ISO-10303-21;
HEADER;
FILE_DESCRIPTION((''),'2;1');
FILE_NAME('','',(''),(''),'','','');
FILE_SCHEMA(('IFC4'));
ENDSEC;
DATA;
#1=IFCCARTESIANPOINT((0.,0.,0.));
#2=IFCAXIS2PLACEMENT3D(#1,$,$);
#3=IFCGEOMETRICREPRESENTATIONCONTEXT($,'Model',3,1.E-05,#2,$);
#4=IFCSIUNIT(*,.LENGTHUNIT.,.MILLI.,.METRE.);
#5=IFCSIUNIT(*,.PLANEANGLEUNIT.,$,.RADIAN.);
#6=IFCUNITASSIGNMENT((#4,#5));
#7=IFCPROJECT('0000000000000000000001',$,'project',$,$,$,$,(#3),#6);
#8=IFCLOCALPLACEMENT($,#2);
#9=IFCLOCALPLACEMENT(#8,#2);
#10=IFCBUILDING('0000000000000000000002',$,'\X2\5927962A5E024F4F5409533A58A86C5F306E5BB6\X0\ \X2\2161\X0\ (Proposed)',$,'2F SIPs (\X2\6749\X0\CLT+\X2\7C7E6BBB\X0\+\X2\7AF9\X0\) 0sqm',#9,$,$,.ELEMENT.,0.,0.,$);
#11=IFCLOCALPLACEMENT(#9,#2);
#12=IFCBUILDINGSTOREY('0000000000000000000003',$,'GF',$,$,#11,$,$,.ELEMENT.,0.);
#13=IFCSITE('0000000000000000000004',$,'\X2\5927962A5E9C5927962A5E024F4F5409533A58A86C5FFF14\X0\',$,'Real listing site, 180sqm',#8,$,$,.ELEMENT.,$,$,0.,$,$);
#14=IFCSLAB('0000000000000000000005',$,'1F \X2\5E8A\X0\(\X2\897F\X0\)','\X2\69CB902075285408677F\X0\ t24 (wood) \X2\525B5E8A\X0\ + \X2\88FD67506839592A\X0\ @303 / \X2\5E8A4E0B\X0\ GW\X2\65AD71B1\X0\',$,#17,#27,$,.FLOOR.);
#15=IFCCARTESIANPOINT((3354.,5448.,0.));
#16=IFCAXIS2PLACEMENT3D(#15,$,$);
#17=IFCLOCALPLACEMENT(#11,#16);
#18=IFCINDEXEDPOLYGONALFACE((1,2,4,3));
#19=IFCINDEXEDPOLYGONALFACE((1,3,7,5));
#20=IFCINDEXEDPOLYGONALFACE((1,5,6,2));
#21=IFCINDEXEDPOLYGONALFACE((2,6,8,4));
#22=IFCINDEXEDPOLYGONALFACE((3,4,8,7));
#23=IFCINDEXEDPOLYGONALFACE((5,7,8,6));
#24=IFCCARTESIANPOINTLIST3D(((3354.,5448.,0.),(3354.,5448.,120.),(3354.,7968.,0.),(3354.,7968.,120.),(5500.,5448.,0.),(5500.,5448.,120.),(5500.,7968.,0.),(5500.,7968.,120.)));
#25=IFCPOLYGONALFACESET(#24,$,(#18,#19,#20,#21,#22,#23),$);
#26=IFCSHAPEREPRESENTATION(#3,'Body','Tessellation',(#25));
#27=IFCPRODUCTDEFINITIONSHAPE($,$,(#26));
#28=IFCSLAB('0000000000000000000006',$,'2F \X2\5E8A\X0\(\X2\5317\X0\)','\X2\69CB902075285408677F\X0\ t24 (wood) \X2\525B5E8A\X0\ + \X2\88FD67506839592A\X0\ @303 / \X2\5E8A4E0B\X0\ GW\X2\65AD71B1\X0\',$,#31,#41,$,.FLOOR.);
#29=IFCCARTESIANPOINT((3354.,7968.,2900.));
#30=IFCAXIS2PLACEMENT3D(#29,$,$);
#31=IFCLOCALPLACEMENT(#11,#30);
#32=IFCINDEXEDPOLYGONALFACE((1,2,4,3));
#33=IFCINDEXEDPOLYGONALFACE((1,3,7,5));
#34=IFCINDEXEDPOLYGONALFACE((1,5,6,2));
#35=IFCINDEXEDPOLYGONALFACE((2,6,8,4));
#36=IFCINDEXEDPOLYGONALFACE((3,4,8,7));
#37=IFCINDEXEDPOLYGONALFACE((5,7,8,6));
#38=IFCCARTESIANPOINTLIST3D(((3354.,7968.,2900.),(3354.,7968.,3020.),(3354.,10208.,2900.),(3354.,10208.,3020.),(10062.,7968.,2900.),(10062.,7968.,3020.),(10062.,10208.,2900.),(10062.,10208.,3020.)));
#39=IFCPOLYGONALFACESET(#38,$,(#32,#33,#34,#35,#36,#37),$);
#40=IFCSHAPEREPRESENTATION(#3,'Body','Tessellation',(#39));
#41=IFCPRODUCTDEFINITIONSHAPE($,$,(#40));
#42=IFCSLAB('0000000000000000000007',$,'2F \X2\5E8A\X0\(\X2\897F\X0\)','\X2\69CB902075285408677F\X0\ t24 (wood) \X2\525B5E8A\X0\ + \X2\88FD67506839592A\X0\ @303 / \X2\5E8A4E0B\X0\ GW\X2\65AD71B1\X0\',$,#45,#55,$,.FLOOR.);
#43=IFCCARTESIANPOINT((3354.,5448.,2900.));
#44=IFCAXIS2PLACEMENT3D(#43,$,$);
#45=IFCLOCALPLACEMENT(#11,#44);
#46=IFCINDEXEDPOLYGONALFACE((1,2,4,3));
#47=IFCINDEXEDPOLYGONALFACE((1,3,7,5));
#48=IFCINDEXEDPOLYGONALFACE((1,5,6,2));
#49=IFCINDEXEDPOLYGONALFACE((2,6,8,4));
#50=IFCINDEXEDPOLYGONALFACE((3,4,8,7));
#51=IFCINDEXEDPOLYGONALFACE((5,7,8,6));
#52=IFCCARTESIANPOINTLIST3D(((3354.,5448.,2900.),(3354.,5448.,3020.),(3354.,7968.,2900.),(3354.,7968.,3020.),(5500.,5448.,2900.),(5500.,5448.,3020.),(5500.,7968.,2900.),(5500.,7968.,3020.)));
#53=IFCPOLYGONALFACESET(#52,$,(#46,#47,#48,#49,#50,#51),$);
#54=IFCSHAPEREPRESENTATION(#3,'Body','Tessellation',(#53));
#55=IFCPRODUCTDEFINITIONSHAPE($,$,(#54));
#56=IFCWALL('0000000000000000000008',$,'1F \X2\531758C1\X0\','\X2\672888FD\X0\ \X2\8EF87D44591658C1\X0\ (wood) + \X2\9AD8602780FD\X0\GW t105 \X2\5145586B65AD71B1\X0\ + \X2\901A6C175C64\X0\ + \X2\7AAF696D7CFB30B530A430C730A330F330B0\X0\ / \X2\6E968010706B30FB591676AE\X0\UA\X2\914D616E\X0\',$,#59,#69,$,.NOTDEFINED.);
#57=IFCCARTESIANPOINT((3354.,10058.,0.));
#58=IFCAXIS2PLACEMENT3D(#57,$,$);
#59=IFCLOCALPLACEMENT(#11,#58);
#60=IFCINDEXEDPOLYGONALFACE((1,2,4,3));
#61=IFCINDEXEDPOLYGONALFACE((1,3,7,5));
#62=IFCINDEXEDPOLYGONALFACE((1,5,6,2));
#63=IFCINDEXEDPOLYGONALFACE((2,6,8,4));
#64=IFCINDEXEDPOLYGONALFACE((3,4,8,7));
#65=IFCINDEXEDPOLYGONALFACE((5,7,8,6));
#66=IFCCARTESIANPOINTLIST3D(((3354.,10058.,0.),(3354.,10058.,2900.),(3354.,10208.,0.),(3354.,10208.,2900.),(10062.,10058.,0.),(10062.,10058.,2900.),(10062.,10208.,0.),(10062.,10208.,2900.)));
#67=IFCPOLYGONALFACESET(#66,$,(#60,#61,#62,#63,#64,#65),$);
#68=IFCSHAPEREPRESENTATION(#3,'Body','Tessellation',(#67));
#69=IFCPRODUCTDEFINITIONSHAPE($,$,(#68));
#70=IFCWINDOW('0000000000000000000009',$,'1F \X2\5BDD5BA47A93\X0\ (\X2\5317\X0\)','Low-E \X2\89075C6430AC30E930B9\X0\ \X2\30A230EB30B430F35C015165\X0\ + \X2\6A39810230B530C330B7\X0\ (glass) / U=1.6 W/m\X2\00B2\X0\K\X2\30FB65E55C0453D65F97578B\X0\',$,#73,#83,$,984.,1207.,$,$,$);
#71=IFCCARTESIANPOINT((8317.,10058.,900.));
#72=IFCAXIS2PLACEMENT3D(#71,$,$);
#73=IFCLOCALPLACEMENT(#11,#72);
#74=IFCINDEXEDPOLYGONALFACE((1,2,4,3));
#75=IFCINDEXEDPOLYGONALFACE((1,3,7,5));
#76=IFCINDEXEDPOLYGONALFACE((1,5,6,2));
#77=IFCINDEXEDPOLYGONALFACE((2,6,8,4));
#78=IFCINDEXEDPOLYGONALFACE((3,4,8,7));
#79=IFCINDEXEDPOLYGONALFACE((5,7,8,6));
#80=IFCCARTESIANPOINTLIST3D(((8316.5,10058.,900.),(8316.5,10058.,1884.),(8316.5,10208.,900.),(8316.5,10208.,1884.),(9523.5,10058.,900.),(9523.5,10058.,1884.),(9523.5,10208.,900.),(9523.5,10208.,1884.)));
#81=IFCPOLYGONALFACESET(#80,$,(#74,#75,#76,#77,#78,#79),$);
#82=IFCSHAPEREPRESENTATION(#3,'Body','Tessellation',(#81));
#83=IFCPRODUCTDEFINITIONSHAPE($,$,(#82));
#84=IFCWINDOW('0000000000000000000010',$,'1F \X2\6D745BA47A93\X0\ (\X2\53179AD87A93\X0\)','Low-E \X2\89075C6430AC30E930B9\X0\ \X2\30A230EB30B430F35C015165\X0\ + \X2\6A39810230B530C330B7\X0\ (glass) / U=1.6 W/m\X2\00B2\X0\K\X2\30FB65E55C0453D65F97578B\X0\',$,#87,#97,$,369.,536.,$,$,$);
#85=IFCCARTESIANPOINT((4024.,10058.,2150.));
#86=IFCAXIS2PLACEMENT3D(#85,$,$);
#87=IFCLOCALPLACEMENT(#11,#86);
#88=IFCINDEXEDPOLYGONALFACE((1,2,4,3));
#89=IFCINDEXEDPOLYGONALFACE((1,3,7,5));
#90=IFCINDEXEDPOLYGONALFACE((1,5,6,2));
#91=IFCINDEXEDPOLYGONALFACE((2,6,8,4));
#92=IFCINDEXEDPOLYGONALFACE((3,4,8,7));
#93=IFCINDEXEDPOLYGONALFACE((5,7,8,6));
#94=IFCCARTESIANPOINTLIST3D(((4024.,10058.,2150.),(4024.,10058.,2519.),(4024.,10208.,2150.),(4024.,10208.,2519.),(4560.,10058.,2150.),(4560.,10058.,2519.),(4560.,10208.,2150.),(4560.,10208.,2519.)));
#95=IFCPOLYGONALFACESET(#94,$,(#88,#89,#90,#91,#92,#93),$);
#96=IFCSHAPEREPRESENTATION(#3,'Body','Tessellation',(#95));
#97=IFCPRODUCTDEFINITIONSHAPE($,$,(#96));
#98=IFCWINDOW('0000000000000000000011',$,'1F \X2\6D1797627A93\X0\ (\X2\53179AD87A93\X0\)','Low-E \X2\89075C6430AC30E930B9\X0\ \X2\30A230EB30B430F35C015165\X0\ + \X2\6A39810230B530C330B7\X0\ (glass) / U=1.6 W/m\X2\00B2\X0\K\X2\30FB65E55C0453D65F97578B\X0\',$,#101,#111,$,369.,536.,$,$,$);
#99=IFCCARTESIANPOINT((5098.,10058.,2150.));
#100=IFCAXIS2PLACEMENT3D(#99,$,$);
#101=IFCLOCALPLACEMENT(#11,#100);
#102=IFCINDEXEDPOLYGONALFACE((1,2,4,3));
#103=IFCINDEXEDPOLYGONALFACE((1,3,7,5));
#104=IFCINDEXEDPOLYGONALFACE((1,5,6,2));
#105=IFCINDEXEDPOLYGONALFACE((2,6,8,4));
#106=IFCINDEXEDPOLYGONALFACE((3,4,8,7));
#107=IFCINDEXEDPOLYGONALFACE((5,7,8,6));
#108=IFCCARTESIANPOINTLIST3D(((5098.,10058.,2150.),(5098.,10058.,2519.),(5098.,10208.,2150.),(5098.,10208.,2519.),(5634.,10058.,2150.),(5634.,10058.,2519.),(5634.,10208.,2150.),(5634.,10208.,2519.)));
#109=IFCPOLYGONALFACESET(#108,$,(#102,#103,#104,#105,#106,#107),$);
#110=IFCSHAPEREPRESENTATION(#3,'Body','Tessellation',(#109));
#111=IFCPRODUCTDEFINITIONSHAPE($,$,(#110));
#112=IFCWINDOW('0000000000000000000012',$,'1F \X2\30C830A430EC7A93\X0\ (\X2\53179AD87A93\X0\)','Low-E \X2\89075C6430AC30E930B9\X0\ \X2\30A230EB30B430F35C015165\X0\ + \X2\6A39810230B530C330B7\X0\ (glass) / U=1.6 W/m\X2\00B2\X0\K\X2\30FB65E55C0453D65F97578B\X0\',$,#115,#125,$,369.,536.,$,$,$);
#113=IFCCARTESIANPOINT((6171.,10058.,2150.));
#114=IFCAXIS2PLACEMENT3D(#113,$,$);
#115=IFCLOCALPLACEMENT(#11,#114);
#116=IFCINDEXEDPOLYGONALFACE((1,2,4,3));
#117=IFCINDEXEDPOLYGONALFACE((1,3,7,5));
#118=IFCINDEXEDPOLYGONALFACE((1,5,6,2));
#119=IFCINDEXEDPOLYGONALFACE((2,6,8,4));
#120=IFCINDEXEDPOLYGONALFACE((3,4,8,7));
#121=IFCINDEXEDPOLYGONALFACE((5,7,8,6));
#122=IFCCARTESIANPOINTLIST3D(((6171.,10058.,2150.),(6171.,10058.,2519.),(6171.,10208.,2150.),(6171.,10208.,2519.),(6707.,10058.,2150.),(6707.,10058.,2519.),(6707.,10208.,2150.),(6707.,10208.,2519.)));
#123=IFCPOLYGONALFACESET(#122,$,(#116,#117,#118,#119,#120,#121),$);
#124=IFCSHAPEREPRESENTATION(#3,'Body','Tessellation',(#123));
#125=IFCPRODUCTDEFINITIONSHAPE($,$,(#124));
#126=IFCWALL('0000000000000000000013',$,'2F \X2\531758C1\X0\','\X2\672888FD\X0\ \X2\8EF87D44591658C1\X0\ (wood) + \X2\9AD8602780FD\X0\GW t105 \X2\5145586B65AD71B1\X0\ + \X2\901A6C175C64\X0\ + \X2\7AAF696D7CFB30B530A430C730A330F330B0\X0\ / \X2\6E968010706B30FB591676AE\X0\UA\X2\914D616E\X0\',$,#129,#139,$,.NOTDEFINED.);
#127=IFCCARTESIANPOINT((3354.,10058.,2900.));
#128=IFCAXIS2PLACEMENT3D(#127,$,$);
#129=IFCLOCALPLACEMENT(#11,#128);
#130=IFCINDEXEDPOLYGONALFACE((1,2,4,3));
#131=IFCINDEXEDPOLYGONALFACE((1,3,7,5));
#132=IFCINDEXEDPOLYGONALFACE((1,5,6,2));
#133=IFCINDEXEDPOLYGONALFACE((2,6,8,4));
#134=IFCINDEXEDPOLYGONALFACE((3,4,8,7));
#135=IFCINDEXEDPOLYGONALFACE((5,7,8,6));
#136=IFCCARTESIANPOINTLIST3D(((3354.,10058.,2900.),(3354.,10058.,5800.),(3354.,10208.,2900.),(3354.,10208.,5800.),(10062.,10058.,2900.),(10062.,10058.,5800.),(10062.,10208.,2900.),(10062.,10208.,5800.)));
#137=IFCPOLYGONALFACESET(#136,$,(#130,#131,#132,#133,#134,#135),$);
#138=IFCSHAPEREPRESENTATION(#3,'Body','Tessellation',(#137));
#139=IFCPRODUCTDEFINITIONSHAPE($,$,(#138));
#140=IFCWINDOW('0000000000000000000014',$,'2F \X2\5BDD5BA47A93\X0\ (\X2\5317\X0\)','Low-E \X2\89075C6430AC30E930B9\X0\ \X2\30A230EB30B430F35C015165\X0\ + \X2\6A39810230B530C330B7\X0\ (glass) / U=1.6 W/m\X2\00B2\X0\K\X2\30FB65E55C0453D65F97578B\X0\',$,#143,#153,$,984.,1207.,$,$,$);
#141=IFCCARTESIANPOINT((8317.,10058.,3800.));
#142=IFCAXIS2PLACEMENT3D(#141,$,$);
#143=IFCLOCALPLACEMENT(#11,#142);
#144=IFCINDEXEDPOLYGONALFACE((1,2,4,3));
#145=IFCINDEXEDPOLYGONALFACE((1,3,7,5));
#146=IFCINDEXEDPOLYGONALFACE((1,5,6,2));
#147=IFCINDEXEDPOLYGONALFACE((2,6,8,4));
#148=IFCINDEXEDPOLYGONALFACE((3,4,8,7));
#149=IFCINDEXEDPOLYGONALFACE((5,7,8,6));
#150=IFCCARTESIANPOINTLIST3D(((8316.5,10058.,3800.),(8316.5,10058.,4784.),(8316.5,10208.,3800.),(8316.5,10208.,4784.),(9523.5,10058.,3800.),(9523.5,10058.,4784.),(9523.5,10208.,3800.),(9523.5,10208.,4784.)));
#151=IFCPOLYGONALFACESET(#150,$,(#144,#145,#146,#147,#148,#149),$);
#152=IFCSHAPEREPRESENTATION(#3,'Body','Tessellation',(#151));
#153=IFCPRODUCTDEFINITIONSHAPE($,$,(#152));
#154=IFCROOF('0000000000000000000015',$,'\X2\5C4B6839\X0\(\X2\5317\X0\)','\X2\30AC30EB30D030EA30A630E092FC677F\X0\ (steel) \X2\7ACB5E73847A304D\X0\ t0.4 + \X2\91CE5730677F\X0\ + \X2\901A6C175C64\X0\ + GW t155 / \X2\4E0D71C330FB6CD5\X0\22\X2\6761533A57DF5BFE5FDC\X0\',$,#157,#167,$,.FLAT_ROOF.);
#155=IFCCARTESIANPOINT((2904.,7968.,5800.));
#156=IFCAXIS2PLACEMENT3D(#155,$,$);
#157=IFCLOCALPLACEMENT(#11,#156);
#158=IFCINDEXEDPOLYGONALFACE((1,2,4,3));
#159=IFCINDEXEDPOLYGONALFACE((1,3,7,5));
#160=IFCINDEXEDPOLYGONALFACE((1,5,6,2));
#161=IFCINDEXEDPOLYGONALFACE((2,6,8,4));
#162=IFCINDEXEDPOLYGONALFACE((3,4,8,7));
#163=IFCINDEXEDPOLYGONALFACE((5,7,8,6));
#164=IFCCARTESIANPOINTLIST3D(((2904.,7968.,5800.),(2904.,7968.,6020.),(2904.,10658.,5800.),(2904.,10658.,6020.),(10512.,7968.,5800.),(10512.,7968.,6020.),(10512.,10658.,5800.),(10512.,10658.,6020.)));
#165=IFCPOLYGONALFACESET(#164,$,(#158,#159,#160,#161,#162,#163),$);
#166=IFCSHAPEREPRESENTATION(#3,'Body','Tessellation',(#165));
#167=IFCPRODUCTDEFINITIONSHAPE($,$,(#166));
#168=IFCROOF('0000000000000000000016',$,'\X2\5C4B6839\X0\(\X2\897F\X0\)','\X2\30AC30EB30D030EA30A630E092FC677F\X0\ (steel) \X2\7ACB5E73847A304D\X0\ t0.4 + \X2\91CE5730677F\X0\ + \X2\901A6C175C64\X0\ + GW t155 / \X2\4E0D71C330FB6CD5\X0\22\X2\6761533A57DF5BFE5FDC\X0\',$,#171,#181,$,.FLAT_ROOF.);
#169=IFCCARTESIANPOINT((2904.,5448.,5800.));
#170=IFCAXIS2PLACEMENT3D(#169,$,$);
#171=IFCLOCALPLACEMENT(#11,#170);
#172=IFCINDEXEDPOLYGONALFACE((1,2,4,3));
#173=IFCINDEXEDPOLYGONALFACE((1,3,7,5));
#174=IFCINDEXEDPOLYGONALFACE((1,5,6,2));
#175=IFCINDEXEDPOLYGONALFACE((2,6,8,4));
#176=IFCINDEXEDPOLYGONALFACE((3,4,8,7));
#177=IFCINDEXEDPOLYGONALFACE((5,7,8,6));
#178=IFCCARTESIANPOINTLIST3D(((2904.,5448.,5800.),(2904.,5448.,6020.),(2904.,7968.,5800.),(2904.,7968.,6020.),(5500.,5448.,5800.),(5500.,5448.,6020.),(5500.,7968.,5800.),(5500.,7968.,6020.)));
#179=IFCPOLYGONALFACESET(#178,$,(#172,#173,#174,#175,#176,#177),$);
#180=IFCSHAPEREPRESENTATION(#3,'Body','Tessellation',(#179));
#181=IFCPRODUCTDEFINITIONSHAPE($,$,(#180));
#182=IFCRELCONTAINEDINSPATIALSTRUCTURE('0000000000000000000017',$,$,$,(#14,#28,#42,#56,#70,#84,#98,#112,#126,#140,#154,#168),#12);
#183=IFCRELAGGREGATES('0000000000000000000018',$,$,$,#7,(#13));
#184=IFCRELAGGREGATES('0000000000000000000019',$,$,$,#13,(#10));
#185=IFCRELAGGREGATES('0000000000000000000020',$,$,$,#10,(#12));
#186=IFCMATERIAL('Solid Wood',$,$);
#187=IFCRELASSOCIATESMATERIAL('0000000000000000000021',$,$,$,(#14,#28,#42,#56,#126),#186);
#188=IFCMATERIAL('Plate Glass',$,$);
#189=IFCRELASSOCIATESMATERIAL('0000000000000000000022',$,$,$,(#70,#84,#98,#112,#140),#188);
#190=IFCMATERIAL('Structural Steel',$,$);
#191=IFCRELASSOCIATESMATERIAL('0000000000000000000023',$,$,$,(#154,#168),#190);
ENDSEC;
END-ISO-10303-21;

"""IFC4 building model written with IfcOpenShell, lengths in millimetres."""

from ifc_helpers import new_model, si_unit, frame, frame_2d, origin, place, context, project, spatial, rectangle, extrude, material, element, fill, save


model = new_model("IFC4")

# Units and contexts
model_context = context("Model", 3, precision=1e-05, world=origin())
ifc_project = project(units=[si_unit("LENGTHUNIT", "METRE", prefix="MILLI"), si_unit("PLANEANGLEUNIT", "RADIAN")], contexts=[model_context])

# Site, building, storey
site_placement = place(None, origin())
site = spatial("IfcSite", under=ifc_project, at=site_placement, Name="大阪府大阪市住吉区墨江４", ObjectType="Real listing site, 180sqm", CompositionType="ELEMENT", RefElevation=0.0)
building_placement = place(site_placement, origin())
building = spatial("IfcBuilding", under=site, at=building_placement, Name="大阪市住吉区墨江の家 Ⅱ (Proposed)", ObjectType="2F SIPs (杉CLT+籾殻+竹) 0sqm", CompositionType="ELEMENT", ElevationOfRefHeight=0.0, ElevationOfTerrain=0.0)
storey_placement = place(building_placement, origin())
storey = spatial("IfcBuildingStorey", under=building, at=storey_placement, Name="GF", CompositionType="ELEMENT", Elevation=0.0)

# Slabs
ifc_material_1 = material(Name="Solid Wood")
slab_1_placement = place(storey_placement, frame((3354.0, 5448.0, 0.0)))
element("IfcSlab", 1, at=slab_1_placement, inside=storey, material=ifc_material_1, Name="1F 床(西)", Description="構造用合板 t24 (wood) 剛床 + 製材根太 @303 / 床下 GW断熱", PredefinedType="FLOOR", context=model_context, shape_type="SweptSolid", body=[
    extrude(rectangle(XDim=2146.0, YDim=2520.0, at=frame_2d((1073.0, 1260.0))), frame((3354.0, 5448.0, 0.0)), (0.0, 0.0, 1.0), 120.0),
])
slab_2_placement = place(storey_placement, frame((3354.0, 7968.0, 2900.0)))
element("IfcSlab", 2, at=slab_2_placement, inside=storey, material=ifc_material_1, Name="2F 床(北)", Description="構造用合板 t24 (wood) 剛床 + 製材根太 @303 / 床下 GW断熱", PredefinedType="FLOOR", context=model_context, shape_type="SweptSolid", body=[
    extrude(rectangle(XDim=6708.0, YDim=2240.0, at=frame_2d((3354.0, 1120.0))), frame((3354.0, 7968.0, 2900.0)), (0.0, 0.0, 1.0), 120.0),
])
slab_3_placement = place(storey_placement, frame((3354.0, 5448.0, 2900.0)))
element("IfcSlab", 3, at=slab_3_placement, inside=storey, material=ifc_material_1, Name="2F 床(西)", Description="構造用合板 t24 (wood) 剛床 + 製材根太 @303 / 床下 GW断熱", PredefinedType="FLOOR", context=model_context, shape_type="SweptSolid", body=[
    extrude(rectangle(XDim=2146.0, YDim=2520.0, at=frame_2d((1073.0, 1260.0))), frame((3354.0, 5448.0, 2900.0)), (0.0, 0.0, 1.0), 120.0),
])

# Wall, openings, windows
wall_1_placement = place(storey_placement, frame((3354.0, 10058.0, 0.0)))
wall_1 = element("IfcWall", 4, at=wall_1_placement, inside=storey, material=ifc_material_1, Name="1F 北壁", Description="木製 軸組外壁 (wood) + 高性能GW t105 充填断熱 + 通気層 + 窯業系サイディング / 準耐火・外皮UA配慮", PredefinedType="NOTDEFINED", context=model_context, shape_type="SweptSolid", body=[
    extrude(rectangle(XDim=6708.0, YDim=150.0, at=frame_2d((3354.0, 75.0))), frame((3354.0, 10058.0, 0.0)), (0.0, 0.0, 1.0), 2900.0),
])
opening_1_placement = place(storey_placement, frame((8317.0, 10058.0, 900.0)))
opening_1 = element("IfcOpeningElement", 5, at=opening_1_placement, cuts=wall_1, PredefinedType="NOTDEFINED", context=model_context, shape_type="SweptSolid", body=[
    extrude(rectangle(XDim=1207.0, YDim=150.0, at=frame_2d((603.0, 75.0))), frame((8317.0, 10058.0, 900.0)), (0.0, 0.0, 1.0), 984.0),
])
opening_2_placement = place(storey_placement, frame((4024.0, 10058.0, 2150.0)))
opening_2 = element("IfcOpeningElement", 6, at=opening_2_placement, cuts=wall_1, PredefinedType="NOTDEFINED", context=model_context, shape_type="SweptSolid", body=[
    extrude(rectangle(XDim=536.0, YDim=150.0, at=frame_2d((268.0, 75.0))), frame((4024.0, 10058.0, 2150.0)), (0.0, 0.0, 1.0), 369.0),
])
opening_3_placement = place(storey_placement, frame((5098.0, 10058.0, 2150.0)))
opening_3 = element("IfcOpeningElement", 7, at=opening_3_placement, cuts=wall_1, PredefinedType="NOTDEFINED", context=model_context, shape_type="SweptSolid", body=[
    extrude(rectangle(XDim=536.0, YDim=150.0, at=frame_2d((268.0, 75.0))), frame((5098.0, 10058.0, 2150.0)), (0.0, 0.0, 1.0), 369.0),
])
opening_4_placement = place(storey_placement, frame((6171.0, 10058.0, 2150.0)))
opening_4 = element("IfcOpeningElement", 8, at=opening_4_placement, cuts=wall_1, PredefinedType="NOTDEFINED", context=model_context, shape_type="SweptSolid", body=[
    extrude(rectangle(XDim=536.0, YDim=150.0, at=frame_2d((268.0, 75.0))), frame((6171.0, 10058.0, 2150.0)), (0.0, 0.0, 1.0), 369.0),
])
ifc_material_2 = material(Name="Plate Glass")
window_1_placement = place(storey_placement, frame((8317.0, 10058.0, 900.0)))
window_1 = element("IfcWindow", 9, at=window_1_placement, inside=storey, material=ifc_material_2, Name="1F 寝室窓 (北)", Description="Low-E 複層ガラス アルゴン封入 + 樹脂サッシ (glass) / U=1.6 W/m²K・日射取得型", OverallHeight=984.0, OverallWidth=1207.0, context=model_context, shape_type="SweptSolid", body=[
    extrude(rectangle(XDim=1207.0, YDim=150.0, at=frame_2d((603.0, 75.0))), frame((8317.0, 10058.0, 900.0)), (0.0, 0.0, 1.0), 984.0),
])
fill(opening_1, window_1)
window_2_placement = place(storey_placement, frame((4024.0, 10058.0, 2150.0)))
window_2 = element("IfcWindow", 10, at=window_2_placement, inside=storey, material=ifc_material_2, Name="1F 浴室窓 (北高窓)", Description="Low-E 複層ガラス アルゴン封入 + 樹脂サッシ (glass) / U=1.6 W/m²K・日射取得型", OverallHeight=369.0, OverallWidth=536.0, context=model_context, shape_type="SweptSolid", body=[
    extrude(rectangle(XDim=536.0, YDim=150.0, at=frame_2d((268.0, 75.0))), frame((4024.0, 10058.0, 2150.0)), (0.0, 0.0, 1.0), 369.0),
])
fill(opening_2, window_2)
window_3_placement = place(storey_placement, frame((5098.0, 10058.0, 2150.0)))
window_3 = element("IfcWindow", 11, at=window_3_placement, inside=storey, material=ifc_material_2, Name="1F 洗面窓 (北高窓)", Description="Low-E 複層ガラス アルゴン封入 + 樹脂サッシ (glass) / U=1.6 W/m²K・日射取得型", OverallHeight=369.0, OverallWidth=536.0, context=model_context, shape_type="SweptSolid", body=[
    extrude(rectangle(XDim=536.0, YDim=150.0, at=frame_2d((268.0, 75.0))), frame((5098.0, 10058.0, 2150.0)), (0.0, 0.0, 1.0), 369.0),
])
fill(opening_3, window_3)
window_4_placement = place(storey_placement, frame((6171.0, 10058.0, 2150.0)))
window_4 = element("IfcWindow", 12, at=window_4_placement, inside=storey, material=ifc_material_2, Name="1F トイレ窓 (北高窓)", Description="Low-E 複層ガラス アルゴン封入 + 樹脂サッシ (glass) / U=1.6 W/m²K・日射取得型", OverallHeight=369.0, OverallWidth=536.0, context=model_context, shape_type="SweptSolid", body=[
    extrude(rectangle(XDim=536.0, YDim=150.0, at=frame_2d((268.0, 75.0))), frame((6171.0, 10058.0, 2150.0)), (0.0, 0.0, 1.0), 369.0),
])
fill(opening_4, window_4)

# Wall, opening, window
wall_2_placement = place(storey_placement, frame((3354.0, 10058.0, 2900.0)))
wall_2 = element("IfcWall", 13, at=wall_2_placement, inside=storey, material=ifc_material_1, Name="2F 北壁", Description="木製 軸組外壁 (wood) + 高性能GW t105 充填断熱 + 通気層 + 窯業系サイディング / 準耐火・外皮UA配慮", PredefinedType="NOTDEFINED", context=model_context, shape_type="SweptSolid", body=[
    extrude(rectangle(XDim=6708.0, YDim=150.0, at=frame_2d((3354.0, 75.0))), frame((3354.0, 10058.0, 2900.0)), (0.0, 0.0, 1.0), 2900.0),
])
opening_5_placement = place(storey_placement, frame((8317.0, 10058.0, 3800.0)))
opening_5 = element("IfcOpeningElement", 14, at=opening_5_placement, cuts=wall_2, PredefinedType="NOTDEFINED", context=model_context, shape_type="SweptSolid", body=[
    extrude(rectangle(XDim=1207.0, YDim=150.0, at=frame_2d((603.0, 75.0))), frame((8317.0, 10058.0, 3800.0)), (0.0, 0.0, 1.0), 984.0),
])
window_5_placement = place(storey_placement, frame((8317.0, 10058.0, 3800.0)))
window_5 = element("IfcWindow", 15, at=window_5_placement, inside=storey, material=ifc_material_2, Name="2F 寝室窓 (北)", Description="Low-E 複層ガラス アルゴン封入 + 樹脂サッシ (glass) / U=1.6 W/m²K・日射取得型", OverallHeight=984.0, OverallWidth=1207.0, context=model_context, shape_type="SweptSolid", body=[
    extrude(rectangle(XDim=1207.0, YDim=150.0, at=frame_2d((603.0, 75.0))), frame((8317.0, 10058.0, 3800.0)), (0.0, 0.0, 1.0), 984.0),
])
fill(opening_5, window_5)

# Roofs
ifc_material_3 = material(Name="Structural Steel")
for number, where, name in (
    (16, (2904.0, 7968.0, 5800.0), "屋根(北)"),
):
    element("IfcRoof", number, at=place(storey_placement, frame(where)), inside=storey, material=ifc_material_3, Name=name, Description="ガルバリウム鋼板 (steel) 立平葺き t0.4 + 野地板 + 通気層 + GW t155 / 不燃・法22条区域対応", PredefinedType="FLAT_ROOF", context=model_context, shape_type="SweptSolid", body=[
        extrude(rectangle(XDim=7608.0, YDim=2690.0, at=frame_2d((3804.0, 1345.0))), frame((2904.0, 7968.0, 5800.0)), (0.0, 0.0, 1.0), 220.0),
    ])
roof_placement = place(storey_placement, frame((2904.0, 5448.0, 5800.0)))
element("IfcRoof", 17, at=roof_placement, inside=storey, material=ifc_material_3, Name="屋根(西)", Description="ガルバリウム鋼板 (steel) 立平葺き t0.4 + 野地板 + 通気層 + GW t155 / 不燃・法22条区域対応", PredefinedType="FLAT_ROOF", context=model_context, shape_type="SweptSolid", body=[
    extrude(rectangle(XDim=2596.0, YDim=2520.0, at=frame_2d((1298.0, 1260.0))), frame((2904.0, 5448.0, 5800.0)), (0.0, 0.0, 1.0), 220.0),
])

save(model, "model.ifc")
